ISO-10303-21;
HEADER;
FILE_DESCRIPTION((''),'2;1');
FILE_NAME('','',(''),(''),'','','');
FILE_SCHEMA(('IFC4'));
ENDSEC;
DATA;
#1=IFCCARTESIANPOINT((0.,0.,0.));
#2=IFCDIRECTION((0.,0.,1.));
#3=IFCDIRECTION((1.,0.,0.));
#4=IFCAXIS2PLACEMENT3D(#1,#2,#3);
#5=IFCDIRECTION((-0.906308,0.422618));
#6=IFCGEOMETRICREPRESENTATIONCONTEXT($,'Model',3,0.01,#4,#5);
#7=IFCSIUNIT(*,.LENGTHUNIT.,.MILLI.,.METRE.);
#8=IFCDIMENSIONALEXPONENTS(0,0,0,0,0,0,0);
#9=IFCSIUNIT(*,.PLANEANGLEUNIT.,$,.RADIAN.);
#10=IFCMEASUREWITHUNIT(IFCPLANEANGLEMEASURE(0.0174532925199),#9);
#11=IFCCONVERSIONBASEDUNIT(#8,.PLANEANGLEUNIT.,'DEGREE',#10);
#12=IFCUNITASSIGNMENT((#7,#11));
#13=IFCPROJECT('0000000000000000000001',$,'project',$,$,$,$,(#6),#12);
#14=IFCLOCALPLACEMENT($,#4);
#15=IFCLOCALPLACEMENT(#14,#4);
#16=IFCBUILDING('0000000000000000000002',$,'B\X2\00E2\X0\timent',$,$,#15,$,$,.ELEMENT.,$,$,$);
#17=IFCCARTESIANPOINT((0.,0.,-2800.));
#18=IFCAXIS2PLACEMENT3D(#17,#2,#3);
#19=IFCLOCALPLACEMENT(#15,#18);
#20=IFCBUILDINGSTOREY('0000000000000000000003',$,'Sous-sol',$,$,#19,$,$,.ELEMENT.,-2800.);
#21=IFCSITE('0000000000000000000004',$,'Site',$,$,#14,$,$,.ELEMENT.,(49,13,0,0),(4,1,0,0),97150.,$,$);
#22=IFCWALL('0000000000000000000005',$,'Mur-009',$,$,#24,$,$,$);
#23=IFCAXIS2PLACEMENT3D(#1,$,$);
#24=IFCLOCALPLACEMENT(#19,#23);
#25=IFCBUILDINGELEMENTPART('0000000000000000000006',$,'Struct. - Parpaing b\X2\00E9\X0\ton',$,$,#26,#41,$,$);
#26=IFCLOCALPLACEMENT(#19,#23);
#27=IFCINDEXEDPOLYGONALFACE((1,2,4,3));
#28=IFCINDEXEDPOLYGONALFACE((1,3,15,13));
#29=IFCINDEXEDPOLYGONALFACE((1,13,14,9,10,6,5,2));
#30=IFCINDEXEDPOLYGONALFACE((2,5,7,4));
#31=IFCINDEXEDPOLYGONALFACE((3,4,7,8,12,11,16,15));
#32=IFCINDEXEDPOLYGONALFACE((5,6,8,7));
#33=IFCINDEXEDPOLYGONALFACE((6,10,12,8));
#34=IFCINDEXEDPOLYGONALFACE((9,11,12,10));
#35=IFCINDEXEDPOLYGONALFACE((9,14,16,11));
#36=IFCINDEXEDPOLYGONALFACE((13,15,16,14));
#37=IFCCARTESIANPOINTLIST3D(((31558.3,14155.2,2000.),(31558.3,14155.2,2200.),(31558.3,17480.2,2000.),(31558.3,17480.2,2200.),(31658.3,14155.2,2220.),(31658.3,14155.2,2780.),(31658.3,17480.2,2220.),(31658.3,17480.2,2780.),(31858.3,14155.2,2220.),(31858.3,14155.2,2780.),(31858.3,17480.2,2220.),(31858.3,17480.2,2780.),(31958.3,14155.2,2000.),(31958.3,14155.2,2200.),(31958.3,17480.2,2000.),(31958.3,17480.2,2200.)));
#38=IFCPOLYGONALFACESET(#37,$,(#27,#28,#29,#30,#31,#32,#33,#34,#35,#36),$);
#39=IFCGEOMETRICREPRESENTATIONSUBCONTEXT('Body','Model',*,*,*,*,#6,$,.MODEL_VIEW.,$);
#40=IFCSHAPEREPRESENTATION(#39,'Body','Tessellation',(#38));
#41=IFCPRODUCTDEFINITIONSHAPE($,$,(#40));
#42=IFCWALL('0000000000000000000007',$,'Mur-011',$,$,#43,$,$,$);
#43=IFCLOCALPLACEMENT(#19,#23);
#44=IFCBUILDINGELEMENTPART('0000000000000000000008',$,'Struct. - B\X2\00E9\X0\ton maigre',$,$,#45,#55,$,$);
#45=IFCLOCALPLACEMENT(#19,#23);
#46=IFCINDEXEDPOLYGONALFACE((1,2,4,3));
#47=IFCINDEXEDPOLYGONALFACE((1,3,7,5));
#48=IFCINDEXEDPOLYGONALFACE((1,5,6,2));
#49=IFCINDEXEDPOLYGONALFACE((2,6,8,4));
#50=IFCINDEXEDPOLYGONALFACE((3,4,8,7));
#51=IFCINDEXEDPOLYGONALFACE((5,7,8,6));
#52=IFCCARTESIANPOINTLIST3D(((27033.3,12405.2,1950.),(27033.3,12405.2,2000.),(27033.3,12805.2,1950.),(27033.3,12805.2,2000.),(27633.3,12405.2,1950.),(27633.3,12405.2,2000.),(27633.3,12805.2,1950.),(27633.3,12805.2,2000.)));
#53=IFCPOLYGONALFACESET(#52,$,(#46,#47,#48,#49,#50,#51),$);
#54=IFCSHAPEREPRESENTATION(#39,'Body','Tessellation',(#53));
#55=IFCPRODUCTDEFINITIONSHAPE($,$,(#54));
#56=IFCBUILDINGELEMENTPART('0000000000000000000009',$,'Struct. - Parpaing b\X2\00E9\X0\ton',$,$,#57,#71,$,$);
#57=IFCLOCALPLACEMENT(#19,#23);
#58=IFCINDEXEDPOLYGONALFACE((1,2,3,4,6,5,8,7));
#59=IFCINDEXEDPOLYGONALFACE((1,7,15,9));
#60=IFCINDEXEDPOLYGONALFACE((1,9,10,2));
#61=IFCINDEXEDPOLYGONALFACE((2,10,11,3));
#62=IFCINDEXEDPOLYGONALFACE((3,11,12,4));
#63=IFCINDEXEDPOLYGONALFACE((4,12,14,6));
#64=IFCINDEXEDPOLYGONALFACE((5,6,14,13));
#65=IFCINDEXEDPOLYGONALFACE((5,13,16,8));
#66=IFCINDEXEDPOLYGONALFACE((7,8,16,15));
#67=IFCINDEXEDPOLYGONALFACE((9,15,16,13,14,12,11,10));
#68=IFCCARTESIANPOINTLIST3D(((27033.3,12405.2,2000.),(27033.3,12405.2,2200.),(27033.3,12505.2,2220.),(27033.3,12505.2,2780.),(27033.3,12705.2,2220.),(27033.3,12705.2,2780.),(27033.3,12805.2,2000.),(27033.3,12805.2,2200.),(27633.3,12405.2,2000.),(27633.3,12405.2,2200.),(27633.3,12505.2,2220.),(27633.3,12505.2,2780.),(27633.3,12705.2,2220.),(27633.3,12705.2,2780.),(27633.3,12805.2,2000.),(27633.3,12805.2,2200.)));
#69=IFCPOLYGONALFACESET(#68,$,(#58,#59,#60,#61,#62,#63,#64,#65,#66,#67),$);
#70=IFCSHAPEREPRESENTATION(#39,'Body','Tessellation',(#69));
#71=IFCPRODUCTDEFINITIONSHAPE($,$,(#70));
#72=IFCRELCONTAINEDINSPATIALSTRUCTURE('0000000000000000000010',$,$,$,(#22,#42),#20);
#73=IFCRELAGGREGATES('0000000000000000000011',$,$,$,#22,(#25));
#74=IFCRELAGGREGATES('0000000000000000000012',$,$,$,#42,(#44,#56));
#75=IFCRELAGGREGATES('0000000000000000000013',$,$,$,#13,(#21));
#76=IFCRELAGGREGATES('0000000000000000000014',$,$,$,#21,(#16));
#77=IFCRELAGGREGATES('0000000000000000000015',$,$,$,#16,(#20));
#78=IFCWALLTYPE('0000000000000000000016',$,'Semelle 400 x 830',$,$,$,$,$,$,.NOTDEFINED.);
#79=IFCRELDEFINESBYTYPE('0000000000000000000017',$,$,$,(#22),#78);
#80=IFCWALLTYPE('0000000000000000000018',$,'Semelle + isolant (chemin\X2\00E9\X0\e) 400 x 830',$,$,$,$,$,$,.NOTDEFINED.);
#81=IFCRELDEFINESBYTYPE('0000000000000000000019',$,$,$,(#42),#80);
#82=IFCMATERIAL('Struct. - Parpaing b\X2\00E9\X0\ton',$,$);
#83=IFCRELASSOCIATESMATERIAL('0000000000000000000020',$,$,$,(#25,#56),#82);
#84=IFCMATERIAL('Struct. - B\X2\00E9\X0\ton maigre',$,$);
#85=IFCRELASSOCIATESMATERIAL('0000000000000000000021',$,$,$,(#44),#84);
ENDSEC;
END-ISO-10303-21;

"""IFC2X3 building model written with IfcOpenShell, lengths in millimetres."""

from ifc_helpers import new_model, entity, si_unit, converted_unit, direction, frame, origin_with_axes, place, context, subcontext, project, spatial, polyline, outline, extrude, material, type_object, element, aggregate, save


model = new_model("IFC2X3")

# Units and contexts
model_context = context("Model", 3, precision=0.01, world=origin_with_axes(), true_north=direction((-0.906308, 0.422618)))
body_context = subcontext(model_context, "Body", "Model", "MODEL_VIEW")
ifc_project = project(units=[si_unit("LENGTHUNIT", "METRE", prefix="MILLI"), converted_unit("PLANEANGLEUNIT", "DEGREE", entity("IfcPlaneAngleMeasure", 0.0174532925199), si_unit("PLANEANGLEUNIT", "RADIAN"), dimensions=[0, 0, 0, 0, 0, 0, 0])], contexts=[model_context])

# Site, building, storey
site_placement = place(None, origin_with_axes())
site = spatial("IfcSite", under=ifc_project, at=site_placement, Name="Site", CompositionType="ELEMENT", RefLatitude=(49, 13, 0, 0), RefLongitude=(4, 1, 0, 0), RefElevation=97150.0)
building_placement = place(site_placement, origin_with_axes())
building = spatial("IfcBuilding", under=site, at=building_placement, Name="Bâtiment", CompositionType="ELEMENT")
storey_placement = place(building_placement, frame((0.0, 0.0, -2800.0), z_axis=(0.0, 0.0, 1.0), x_axis=(1.0, 0.0, 0.0)))
storey = spatial("IfcBuildingStorey", under=building, at=storey_placement, Name="Sous-sol", CompositionType="ELEMENT", Elevation=-2800.0)

# Wall, building element part
wall_type_1 = type_object("IfcWallType", Name="Semelle 400 x 830", PredefinedType="NOTDEFINED")
ifc_material_1 = material(Name="Struct. - Béton maigre")
ifc_material_2 = material(Name="Struct. - Parpaing béton")
wall_type_2 = type_object("IfcWallType", Name="Semelle + isolant (cheminée) 400 x 830", PredefinedType="NOTDEFINED")
wall_1_placement = place(storey_placement, frame((31758.3, 14155.2, 2000.0), z_axis=(0.0, 0.0, 1.0), x_axis=(0.0, 1.0, 0.0)))
wall_1 = element("IfcWall", 1, at=wall_1_placement, inside=storey, type_object=wall_type_1, Name="Mur-009")
building_element_part_1_placement = place(wall_1_placement, origin_with_axes())
building_element_part_1 = element("IfcBuildingElementPart", 2, at=building_element_part_1_placement, material=ifc_material_2, Name="Struct. - Parpaing béton", context=body_context, shape_type="SweptSolid", body=[
    extrude(outline(polyline([(-200.0, 200.0), (-200.0, 0.0), (200.0, 0.0), (200.0, 200.0), (100.0, 220.0), (100.0, 780.0), (-100.0, 780.0), (-100.0, 220.0), (-200.0, 200.0)])), frame((0.0, 0.0, 0.0), z_axis=(-1.0, 0.0, 0.0), x_axis=(0.0, -1.0, 0.0)), (0.0, 0.0, -1.0), 3325.0),
])
aggregate(wall_1, [building_element_part_1])

# Wall, building element parts
wall_2_placement = place(storey_placement, frame((27633.3, 12605.2, 2000.0), z_axis=(0.0, 0.0, 1.0), x_axis=(-1.0, 0.0, 0.0)))
wall_2 = element("IfcWall", 3, at=wall_2_placement, inside=storey, type_object=wall_type_2, Name="Mur-011")
building_element_part_2_placement = place(wall_2_placement, origin_with_axes())
building_element_part_2 = element("IfcBuildingElementPart", 4, at=building_element_part_2_placement, material=ifc_material_1, Name="Struct. - Béton maigre", context=body_context, shape_type="SweptSolid", body=[
    extrude(outline(polyline([(-200.0, 0.0), (-200.0, -50.0), (200.0, -50.0), (200.0, 0.0), (-200.0, 0.0)])), frame((0.0, 0.0, 0.0), z_axis=(-1.0, 0.0, 0.0), x_axis=(0.0, -1.0, 0.0)), (0.0, 0.0, -1.0), 600.0),
])
building_element_part_3_placement = place(wall_2_placement, origin_with_axes())
building_element_part_3 = element("IfcBuildingElementPart", 5, at=building_element_part_3_placement, material=ifc_material_2, Name="Struct. - Parpaing béton", context=body_context, shape_type="SweptSolid", body=[
    extrude(outline(polyline([(-100.0, 220.0), (-200.0, 200.0), (-200.0, 0.0), (200.0, 0.0), (200.0, 200.0), (100.0, 220.0), (100.0, 780.0), (-100.0, 780.0), (-100.0, 220.0)])), frame((0.0, 0.0, 0.0), z_axis=(-1.0, 0.0, 0.0), x_axis=(0.0, -1.0, 0.0)), (0.0, 0.0, -1.0), 600.0),
])
aggregate(wall_2, [building_element_part_2, building_element_part_3])

save(model, "model.ifc")
